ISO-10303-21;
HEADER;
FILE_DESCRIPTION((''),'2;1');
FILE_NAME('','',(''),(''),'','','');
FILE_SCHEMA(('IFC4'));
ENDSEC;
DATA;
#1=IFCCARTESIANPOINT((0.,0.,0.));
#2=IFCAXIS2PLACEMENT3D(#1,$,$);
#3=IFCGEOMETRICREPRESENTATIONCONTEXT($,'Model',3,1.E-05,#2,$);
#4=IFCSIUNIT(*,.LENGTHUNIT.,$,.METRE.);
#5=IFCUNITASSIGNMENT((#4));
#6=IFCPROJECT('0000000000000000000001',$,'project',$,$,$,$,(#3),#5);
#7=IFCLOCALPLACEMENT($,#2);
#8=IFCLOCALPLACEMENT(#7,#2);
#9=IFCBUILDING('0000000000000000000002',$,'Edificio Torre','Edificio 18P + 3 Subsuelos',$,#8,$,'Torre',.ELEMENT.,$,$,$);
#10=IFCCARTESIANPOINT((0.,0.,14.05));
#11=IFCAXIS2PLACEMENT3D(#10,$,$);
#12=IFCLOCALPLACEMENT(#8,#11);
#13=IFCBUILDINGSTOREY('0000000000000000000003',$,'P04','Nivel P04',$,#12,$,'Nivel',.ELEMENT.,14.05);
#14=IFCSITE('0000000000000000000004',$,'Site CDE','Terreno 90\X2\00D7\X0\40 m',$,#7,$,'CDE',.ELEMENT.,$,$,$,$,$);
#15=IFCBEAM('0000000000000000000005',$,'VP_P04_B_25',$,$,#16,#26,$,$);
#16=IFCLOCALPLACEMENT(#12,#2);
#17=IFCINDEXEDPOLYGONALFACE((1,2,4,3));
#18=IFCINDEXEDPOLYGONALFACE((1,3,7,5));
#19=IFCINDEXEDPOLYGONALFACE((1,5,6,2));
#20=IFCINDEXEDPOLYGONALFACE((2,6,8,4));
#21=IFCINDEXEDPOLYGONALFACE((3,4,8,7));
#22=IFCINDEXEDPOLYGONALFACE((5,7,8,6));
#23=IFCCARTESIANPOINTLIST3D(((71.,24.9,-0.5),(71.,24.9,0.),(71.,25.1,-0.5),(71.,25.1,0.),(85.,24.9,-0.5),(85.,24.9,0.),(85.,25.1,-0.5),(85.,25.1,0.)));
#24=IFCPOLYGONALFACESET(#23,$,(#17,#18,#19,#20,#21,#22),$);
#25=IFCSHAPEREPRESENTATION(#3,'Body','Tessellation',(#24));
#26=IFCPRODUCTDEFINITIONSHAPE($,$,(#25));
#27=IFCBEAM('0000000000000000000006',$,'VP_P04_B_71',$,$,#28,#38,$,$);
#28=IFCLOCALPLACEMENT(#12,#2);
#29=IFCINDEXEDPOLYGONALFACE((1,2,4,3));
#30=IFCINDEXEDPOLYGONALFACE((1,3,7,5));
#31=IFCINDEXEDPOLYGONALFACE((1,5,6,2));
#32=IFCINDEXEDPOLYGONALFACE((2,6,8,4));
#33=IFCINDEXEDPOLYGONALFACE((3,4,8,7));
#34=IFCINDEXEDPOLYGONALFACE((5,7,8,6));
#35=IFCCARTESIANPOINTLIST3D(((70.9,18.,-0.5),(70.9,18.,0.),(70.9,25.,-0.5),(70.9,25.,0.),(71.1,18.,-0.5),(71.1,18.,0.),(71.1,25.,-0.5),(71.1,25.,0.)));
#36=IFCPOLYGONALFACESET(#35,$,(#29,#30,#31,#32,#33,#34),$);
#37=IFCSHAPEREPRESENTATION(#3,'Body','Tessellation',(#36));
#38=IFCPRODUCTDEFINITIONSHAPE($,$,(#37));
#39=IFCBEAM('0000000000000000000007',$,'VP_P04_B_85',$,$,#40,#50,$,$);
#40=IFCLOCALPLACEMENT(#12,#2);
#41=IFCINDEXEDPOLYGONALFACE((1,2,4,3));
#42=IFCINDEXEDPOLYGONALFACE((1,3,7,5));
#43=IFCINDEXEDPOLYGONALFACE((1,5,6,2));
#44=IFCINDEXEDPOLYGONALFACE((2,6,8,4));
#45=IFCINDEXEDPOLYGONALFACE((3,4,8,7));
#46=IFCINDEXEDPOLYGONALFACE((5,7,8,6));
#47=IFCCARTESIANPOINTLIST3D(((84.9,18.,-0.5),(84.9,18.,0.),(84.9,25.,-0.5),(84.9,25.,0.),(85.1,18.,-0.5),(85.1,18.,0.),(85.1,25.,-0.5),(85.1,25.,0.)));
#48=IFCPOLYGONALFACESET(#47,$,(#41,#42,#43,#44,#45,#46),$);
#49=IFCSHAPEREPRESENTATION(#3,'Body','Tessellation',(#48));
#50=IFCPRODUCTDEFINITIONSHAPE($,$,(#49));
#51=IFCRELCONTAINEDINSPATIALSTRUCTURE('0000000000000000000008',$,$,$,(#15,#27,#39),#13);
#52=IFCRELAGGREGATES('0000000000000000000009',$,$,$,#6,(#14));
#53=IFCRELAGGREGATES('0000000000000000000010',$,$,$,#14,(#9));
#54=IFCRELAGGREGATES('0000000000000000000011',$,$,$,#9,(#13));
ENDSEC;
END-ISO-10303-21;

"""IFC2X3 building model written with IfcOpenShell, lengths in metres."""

from ifc_helpers import new_model, si_unit, frame, origin, origin_2d, place, context, project, spatial, rectangle, extrude, element, save


model = new_model("IFC2X3")

# Units and contexts
model_context = context("Model", 3, precision=1e-05, world=origin())
ifc_project = project(units=[si_unit("LENGTHUNIT", "METRE")], contexts=[model_context])

# Site, building, storey
site_placement = place(None, origin())
site = spatial("IfcSite", under=ifc_project, at=site_placement, Name="Site CDE", Description="Terreno 90×40 m", LongName="CDE", CompositionType="ELEMENT")
building_placement = place(site_placement, origin())
building = spatial("IfcBuilding", under=site, at=building_placement, Name="Edificio Torre", Description="Edificio 18P + 3 Subsuelos", LongName="Torre", CompositionType="ELEMENT")
storey_placement = place(building_placement, frame((0.0, 0.0, 14.05)))
storey = spatial("IfcBuildingStorey", under=building, at=storey_placement, Name="P04", Description="Nivel P04", LongName="Nivel", CompositionType="ELEMENT", Elevation=14.05)

# Beams
for number, where, name in (
    (1, (78.0, 25.0, -0.5), "VP_P04_B_25"),
):
    element("IfcBeam", number, at=place(storey_placement, frame(where)), inside=storey, Name=name, context=model_context, shape_type="SweptSolid", body=[
        extrude(rectangle(XDim=14.0, YDim=0.2, at=origin_2d()), origin(), (0.0, 0.0, 1.0), 0.5),
    ])
for number, where, name in (
    (2, (71.0, 21.5, -0.5), "VP_P04_B_71"),
    (3, (85.0, 21.5, -0.5), "VP_P04_B_85"),
):
    element("IfcBeam", number, at=place(storey_placement, frame(where)), inside=storey, Name=name, context=model_context, shape_type="SweptSolid", body=[
        extrude(rectangle(XDim=0.2, YDim=7.0, at=origin_2d()), origin(), (0.0, 0.0, 1.0), 0.5),
    ])

save(model, "model.ifc")
